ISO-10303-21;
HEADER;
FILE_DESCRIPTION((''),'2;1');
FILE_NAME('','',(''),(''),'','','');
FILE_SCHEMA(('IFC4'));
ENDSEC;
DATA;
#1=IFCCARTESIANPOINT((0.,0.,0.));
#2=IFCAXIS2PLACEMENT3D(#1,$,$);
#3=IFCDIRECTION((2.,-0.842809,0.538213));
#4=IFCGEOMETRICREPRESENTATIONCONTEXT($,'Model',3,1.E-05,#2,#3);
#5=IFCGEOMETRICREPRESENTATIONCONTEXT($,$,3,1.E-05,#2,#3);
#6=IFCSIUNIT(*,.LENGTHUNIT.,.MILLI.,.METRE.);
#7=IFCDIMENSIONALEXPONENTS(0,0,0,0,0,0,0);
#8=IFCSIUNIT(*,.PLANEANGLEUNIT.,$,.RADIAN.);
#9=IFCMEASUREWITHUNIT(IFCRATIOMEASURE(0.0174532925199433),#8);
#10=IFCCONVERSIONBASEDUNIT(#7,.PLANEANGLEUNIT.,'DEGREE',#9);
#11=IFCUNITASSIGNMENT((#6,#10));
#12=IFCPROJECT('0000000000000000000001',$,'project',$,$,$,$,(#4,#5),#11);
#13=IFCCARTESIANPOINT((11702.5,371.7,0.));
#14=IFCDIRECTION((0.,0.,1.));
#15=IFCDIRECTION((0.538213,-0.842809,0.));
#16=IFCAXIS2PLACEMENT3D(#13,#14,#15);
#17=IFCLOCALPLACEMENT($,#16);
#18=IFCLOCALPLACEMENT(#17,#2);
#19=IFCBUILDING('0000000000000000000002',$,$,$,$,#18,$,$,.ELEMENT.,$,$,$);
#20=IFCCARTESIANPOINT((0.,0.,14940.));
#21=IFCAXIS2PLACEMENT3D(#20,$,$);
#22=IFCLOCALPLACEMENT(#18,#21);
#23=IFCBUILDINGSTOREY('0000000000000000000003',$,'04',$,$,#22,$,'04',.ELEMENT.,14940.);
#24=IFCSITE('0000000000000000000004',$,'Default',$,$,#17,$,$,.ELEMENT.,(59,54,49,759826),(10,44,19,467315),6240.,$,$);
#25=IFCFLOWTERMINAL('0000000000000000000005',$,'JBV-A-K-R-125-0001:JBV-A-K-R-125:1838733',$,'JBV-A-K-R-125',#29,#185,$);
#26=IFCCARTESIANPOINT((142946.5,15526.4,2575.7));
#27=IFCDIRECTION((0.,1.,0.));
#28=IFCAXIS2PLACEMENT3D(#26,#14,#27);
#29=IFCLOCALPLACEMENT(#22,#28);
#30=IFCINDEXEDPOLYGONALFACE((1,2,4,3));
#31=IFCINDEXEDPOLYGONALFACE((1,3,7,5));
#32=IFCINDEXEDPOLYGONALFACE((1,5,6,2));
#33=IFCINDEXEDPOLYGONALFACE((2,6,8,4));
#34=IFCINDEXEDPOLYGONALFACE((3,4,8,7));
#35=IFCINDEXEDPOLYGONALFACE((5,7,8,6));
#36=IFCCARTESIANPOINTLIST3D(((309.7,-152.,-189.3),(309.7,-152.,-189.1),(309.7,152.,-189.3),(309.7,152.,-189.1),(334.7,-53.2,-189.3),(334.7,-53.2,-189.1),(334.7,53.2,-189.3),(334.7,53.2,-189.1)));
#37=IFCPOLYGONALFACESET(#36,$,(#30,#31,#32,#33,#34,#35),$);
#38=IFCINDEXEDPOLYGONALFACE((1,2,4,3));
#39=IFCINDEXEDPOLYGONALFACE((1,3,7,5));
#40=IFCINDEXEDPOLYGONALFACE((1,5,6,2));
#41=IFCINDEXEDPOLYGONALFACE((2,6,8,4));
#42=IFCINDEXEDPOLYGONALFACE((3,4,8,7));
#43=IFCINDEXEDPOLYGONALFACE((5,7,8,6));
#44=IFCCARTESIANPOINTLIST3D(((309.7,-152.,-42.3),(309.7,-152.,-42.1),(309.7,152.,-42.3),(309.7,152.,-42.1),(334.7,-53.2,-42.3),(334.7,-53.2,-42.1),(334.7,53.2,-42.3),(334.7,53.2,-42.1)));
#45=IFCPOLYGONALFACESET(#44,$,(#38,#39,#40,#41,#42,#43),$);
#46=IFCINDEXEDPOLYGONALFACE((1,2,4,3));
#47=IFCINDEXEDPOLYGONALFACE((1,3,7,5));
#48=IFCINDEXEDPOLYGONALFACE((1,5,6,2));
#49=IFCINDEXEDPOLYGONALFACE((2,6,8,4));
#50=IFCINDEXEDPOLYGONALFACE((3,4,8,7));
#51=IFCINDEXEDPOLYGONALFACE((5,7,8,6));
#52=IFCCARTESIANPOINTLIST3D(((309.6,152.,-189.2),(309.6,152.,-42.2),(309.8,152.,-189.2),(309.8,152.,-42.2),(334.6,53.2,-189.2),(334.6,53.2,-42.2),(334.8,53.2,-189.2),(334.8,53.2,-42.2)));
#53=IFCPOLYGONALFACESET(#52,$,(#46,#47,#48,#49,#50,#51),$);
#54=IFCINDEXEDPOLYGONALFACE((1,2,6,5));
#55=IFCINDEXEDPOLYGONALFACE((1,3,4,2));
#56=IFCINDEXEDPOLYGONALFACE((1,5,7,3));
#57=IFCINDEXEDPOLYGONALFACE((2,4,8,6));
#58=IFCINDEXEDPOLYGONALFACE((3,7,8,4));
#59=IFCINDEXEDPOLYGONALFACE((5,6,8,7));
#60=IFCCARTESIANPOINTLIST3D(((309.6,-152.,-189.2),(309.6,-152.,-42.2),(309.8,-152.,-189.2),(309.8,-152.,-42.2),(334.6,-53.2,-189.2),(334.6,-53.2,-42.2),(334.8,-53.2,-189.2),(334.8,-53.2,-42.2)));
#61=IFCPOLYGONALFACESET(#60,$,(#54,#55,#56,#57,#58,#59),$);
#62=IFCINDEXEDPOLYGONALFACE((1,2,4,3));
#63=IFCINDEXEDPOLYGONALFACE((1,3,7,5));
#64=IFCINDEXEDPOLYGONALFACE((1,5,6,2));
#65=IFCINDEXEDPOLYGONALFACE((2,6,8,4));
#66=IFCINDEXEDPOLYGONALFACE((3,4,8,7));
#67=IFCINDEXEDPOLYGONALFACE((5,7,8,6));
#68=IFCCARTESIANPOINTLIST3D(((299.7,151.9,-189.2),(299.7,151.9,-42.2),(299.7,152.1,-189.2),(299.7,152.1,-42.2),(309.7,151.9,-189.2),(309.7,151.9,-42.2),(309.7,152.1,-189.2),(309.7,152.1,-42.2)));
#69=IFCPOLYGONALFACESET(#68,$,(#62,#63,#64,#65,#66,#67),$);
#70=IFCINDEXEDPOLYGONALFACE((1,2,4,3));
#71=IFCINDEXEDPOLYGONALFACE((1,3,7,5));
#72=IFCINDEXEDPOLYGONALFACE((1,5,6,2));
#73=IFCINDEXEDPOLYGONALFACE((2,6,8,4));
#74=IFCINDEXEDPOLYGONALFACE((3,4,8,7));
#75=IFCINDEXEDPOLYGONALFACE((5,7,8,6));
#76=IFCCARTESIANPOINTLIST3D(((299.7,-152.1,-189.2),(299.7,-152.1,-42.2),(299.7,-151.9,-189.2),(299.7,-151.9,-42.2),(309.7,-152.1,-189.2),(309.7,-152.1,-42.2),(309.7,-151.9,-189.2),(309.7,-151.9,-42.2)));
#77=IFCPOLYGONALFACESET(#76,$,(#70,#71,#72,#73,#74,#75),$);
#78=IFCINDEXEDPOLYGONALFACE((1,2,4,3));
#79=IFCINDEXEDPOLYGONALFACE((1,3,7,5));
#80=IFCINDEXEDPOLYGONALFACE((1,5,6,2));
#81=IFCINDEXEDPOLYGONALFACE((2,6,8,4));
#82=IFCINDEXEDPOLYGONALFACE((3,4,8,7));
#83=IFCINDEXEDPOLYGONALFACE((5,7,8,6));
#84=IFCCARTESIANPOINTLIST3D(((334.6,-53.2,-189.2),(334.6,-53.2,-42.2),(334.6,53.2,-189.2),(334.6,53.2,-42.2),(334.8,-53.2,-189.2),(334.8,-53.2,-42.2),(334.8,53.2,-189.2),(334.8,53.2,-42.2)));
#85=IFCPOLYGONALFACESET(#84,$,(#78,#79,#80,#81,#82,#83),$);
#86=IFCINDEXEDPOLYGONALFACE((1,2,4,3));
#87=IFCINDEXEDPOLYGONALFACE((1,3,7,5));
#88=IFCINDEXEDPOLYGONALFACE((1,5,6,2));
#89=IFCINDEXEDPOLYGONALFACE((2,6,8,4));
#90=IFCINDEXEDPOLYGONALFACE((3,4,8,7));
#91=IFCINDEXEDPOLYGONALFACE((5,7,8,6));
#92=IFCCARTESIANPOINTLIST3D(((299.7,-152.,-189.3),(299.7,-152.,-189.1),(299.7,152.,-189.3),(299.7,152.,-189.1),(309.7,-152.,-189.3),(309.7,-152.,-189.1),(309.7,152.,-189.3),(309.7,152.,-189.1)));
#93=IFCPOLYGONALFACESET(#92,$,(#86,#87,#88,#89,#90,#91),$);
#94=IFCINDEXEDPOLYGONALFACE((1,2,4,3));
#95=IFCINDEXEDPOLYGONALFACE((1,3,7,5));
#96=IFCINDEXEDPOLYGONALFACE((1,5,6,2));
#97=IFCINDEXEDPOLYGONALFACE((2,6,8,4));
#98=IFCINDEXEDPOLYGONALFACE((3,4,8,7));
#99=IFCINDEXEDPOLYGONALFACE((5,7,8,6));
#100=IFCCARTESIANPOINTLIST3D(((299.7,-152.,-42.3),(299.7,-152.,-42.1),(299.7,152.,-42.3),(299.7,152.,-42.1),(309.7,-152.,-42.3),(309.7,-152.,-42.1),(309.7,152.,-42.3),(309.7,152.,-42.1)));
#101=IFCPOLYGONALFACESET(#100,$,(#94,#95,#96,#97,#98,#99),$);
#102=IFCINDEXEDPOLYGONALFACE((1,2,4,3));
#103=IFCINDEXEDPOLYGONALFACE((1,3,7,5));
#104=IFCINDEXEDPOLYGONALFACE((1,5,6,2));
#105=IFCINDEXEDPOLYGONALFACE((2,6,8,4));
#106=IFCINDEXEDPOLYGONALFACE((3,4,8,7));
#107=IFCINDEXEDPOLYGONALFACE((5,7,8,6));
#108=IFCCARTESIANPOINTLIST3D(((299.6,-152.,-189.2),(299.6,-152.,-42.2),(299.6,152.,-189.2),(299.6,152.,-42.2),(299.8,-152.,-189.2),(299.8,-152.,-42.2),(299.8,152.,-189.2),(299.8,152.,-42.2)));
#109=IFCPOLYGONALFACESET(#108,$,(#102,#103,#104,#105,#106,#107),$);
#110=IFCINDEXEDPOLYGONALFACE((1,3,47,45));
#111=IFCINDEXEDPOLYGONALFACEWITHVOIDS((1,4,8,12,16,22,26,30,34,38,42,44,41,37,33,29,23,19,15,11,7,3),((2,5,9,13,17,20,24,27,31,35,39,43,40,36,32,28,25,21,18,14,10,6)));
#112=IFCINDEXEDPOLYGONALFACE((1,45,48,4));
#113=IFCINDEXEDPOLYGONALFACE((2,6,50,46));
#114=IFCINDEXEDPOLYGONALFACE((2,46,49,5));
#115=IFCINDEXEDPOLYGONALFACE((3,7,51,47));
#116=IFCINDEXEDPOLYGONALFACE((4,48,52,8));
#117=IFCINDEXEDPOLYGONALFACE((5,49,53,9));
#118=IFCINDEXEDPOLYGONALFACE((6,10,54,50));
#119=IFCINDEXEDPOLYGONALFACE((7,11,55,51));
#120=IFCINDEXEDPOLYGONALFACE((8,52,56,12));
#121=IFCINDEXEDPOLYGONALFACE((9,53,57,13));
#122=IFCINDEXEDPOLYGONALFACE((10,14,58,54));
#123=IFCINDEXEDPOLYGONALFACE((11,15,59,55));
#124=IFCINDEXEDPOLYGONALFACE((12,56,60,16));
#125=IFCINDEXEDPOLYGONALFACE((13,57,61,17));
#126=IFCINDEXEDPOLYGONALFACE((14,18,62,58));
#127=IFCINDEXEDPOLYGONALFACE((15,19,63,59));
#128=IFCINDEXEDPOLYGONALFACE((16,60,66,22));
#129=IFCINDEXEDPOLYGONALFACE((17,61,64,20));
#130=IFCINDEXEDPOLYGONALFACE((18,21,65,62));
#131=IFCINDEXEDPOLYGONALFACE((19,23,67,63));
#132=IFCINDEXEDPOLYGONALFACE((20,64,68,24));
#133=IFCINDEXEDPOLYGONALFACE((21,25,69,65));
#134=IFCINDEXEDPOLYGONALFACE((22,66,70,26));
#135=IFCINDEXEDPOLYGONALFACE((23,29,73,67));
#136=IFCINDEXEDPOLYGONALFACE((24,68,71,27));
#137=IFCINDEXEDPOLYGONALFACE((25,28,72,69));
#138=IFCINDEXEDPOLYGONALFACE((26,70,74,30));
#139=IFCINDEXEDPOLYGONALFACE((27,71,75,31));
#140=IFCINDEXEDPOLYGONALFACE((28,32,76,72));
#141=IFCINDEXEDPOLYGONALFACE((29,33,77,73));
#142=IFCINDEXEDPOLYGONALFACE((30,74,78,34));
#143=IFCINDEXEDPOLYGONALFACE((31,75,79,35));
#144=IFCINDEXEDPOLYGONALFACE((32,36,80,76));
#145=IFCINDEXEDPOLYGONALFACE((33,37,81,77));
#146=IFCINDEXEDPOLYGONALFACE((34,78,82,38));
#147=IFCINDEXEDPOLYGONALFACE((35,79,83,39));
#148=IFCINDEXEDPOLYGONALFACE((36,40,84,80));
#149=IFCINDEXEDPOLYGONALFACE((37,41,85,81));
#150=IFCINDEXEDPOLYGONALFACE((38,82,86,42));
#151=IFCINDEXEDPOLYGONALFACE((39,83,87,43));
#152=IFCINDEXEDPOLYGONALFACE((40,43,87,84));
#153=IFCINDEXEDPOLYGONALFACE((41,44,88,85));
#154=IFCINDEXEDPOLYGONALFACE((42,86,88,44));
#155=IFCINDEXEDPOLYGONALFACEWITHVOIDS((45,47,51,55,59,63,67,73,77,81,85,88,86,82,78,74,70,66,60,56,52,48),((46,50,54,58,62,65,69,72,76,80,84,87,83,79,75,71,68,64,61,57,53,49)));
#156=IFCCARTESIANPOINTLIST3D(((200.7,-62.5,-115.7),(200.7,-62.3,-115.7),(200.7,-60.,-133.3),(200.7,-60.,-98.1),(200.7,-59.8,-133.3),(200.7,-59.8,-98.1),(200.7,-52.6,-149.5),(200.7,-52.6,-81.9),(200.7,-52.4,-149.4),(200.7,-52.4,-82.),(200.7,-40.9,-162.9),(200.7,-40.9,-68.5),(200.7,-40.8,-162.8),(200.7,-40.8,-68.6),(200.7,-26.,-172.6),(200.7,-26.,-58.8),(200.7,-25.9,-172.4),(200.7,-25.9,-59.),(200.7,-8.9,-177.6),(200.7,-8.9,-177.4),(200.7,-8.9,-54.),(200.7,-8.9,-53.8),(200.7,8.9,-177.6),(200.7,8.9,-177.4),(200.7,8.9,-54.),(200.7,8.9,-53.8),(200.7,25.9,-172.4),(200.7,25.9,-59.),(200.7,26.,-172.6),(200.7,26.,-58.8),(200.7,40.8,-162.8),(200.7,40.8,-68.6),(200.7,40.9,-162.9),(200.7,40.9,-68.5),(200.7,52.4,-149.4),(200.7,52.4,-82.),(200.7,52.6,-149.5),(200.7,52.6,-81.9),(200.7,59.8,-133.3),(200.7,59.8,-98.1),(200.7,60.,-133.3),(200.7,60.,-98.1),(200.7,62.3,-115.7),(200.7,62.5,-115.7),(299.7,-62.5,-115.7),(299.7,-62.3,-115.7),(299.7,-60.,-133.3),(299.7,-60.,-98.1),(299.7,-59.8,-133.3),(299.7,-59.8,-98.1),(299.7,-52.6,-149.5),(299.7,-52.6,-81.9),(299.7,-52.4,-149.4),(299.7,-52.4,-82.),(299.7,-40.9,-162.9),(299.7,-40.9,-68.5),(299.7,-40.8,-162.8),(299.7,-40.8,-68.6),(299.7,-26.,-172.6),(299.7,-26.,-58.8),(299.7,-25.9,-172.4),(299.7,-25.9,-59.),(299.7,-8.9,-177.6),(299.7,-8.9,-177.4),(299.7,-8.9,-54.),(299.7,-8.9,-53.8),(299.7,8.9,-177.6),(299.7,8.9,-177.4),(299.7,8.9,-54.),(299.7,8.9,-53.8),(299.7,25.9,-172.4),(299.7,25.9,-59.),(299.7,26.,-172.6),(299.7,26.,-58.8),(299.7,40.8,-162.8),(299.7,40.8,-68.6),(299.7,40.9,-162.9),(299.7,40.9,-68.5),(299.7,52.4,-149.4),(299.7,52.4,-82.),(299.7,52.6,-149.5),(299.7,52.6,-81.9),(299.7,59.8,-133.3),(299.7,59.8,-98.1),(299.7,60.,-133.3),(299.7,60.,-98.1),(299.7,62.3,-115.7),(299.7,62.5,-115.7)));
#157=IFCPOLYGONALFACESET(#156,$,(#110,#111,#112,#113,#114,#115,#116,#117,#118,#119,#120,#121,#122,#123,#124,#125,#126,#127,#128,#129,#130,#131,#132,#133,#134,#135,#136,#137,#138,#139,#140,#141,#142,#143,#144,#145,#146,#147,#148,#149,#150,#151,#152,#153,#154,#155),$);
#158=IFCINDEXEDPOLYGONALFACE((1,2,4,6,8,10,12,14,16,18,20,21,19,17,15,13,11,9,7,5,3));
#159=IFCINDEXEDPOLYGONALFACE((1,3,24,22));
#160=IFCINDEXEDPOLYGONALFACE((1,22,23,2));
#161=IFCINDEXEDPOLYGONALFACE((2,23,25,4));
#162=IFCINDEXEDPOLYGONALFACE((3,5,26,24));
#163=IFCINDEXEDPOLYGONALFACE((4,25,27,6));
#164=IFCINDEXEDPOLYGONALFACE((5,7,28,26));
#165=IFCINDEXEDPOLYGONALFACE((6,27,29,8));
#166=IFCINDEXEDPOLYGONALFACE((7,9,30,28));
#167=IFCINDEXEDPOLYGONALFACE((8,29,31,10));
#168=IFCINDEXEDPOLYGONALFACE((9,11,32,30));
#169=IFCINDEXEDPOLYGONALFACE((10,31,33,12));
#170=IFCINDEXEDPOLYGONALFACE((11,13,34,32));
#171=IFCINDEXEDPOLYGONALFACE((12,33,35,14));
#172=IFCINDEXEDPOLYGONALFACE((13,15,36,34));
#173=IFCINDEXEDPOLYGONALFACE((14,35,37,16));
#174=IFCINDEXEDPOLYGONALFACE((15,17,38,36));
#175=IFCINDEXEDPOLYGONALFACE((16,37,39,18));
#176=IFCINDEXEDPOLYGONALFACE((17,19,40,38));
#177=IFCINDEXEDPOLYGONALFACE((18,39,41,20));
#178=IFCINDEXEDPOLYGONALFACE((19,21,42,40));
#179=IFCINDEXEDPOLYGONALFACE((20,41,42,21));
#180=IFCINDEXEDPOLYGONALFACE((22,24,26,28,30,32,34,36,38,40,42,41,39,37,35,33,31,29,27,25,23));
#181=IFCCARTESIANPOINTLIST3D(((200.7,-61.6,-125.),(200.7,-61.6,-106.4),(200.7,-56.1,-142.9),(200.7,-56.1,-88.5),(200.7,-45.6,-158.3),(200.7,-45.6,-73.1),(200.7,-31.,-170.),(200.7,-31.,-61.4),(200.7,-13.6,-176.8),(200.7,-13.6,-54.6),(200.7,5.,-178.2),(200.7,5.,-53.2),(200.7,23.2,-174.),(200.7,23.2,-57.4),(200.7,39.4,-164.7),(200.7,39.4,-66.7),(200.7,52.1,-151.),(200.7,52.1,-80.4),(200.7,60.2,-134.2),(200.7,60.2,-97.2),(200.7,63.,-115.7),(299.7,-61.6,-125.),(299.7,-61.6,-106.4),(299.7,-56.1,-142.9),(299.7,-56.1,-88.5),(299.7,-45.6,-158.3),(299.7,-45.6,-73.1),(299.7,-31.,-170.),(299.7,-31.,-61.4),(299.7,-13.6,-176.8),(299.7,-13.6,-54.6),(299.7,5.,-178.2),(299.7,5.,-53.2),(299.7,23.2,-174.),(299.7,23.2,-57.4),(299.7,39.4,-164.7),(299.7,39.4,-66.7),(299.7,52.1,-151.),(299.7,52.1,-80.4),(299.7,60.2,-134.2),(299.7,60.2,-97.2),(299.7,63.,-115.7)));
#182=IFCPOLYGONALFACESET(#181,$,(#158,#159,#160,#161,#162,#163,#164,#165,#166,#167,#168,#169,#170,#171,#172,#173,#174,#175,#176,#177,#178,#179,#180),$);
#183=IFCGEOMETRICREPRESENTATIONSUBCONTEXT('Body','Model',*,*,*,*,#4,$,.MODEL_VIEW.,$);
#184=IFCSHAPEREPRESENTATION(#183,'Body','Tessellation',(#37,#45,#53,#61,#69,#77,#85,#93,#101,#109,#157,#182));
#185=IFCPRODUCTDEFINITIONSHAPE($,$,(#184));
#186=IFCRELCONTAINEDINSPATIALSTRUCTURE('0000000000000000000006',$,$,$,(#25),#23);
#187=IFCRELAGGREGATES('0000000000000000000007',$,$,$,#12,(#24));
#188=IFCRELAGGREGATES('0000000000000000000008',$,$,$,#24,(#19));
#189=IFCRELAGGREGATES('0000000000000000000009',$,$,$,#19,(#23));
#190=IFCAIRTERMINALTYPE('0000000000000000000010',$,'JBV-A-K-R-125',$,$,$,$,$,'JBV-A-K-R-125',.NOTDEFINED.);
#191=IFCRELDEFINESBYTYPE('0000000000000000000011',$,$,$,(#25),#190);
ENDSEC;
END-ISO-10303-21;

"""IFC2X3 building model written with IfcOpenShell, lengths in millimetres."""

from ifc_helpers import new_model, entity, si_unit, converted_unit, direction, frame, frame_2d, origin, origin_2d_with_axis, place, context, subcontext, project, spatial, polyline, circle_curve, parameter, trimmed, segment, composite_curve, rectangle, circle, outline, extrude, source, transform, mapped, type_object, type_shapes, element, save


model = new_model("IFC2X3")

# Units and contexts
model_context = context("Model", 3, precision=1e-05, world=origin(), true_north=direction((2.0, -0.842809, 0.538213)))
context_of_model = context(None, 3, precision=1e-05, world=origin(), true_north=direction((2.0, -0.842809, 0.538213)))
body_context = subcontext(model_context, "Body", "Model", "MODEL_VIEW")
ifc_project = project(units=[si_unit("LENGTHUNIT", "METRE", prefix="MILLI"), converted_unit("PLANEANGLEUNIT", "DEGREE", entity("IfcRatioMeasure", 0.0174532925199433), si_unit("PLANEANGLEUNIT", "RADIAN"), dimensions=[0, 0, 0, 0, 0, 0, 0])], contexts=[model_context, context_of_model])

# Site, building, storey
site_placement = place(None, frame((11702.5, 371.7, 0.0), z_axis=(0.0, 0.0, 1.0), x_axis=(0.538213, -0.842809, 0.0)))
site = spatial("IfcSite", under=ifc_project, at=site_placement, Name="Default", CompositionType="ELEMENT", RefLatitude=(59, 54, 49, 759826), RefLongitude=(10, 44, 19, 467315), RefElevation=6240.0)
building_placement = place(site_placement, origin())
building = spatial("IfcBuilding", under=site, at=building_placement, CompositionType="ELEMENT")
storey_placement = place(building_placement, frame((0.0, 0.0, 14940.0)))
storey = spatial("IfcBuildingStorey", under=building, at=storey_placement, Name="04", LongName="04", CompositionType="ELEMENT", Elevation=14940.0)

# Flow terminal
air_terminal_type_1 = type_object("IfcAirTerminalType", Name="JBV-A-K-R-125", ElementType="JBV-A-K-R-125", PredefinedType="NOTDEFINED")
shared_shape_1 = source(origin(), body_context, "Body", "SweptSolid", [
    extrude(outline(polyline([(-152.0, -12.5), (152.0, -12.5), (53.2, 12.5), (-53.2, 12.5), (-152.0, -12.5)])), frame((322.2, 0.0, -189.3), z_axis=(0.0, 0.0, 1.0), x_axis=(0.0, -1.0, 0.0)), (0.0, 0.0, 1.0), 0.2),
    extrude(outline(polyline([(-152.0, -12.5), (152.0, -12.5), (53.2, 12.5), (-53.2, 12.5), (-152.0, -12.5)])), frame((322.2, 0.0, -42.3), z_axis=(0.0, 0.0, 1.0), x_axis=(0.0, -1.0, 0.0)), (0.0, 0.0, 1.0), 0.2),
    extrude(rectangle(XDim=0.2, YDim=101.9, at=frame_2d((0.0, 0.0), x_axis=(1.0, 0.0))), frame((322.2, 102.6, -189.2), z_axis=(0.0, 0.0, 1.0), x_axis=(0.969446, 0.245305, 0.0)), (0.0, 0.0, 1.0), 147.0),
    extrude(rectangle(XDim=0.2, YDim=101.9, at=frame_2d((0.0, 0.0), x_axis=(1.0, 0.0))), frame((322.2, -102.6, -189.2), z_axis=(0.0, 0.0, 1.0), x_axis=(-0.969446, 0.245305, 0.0)), (0.0, 0.0, 1.0), 147.0),
    extrude(rectangle(XDim=0.2, YDim=10.0, at=frame_2d((0.0, 0.0), x_axis=(1.0, 0.0))), frame((304.7, 152.0, -189.2), z_axis=(0.0, 0.0, 1.0), x_axis=(0.0, 1.0, 0.0)), (0.0, 0.0, 1.0), 147.0),
    extrude(rectangle(XDim=0.2, YDim=10.0, at=frame_2d((0.0, 0.0), x_axis=(1.0, 0.0))), frame((304.7, -152.0, -189.2), z_axis=(0.0, 0.0, 1.0), x_axis=(0.0, 1.0, 0.0)), (0.0, 0.0, 1.0), 147.0),
    extrude(rectangle(XDim=0.2, YDim=106.4, at=frame_2d((0.0, 0.0), x_axis=(1.0, 0.0))), frame((334.7, 0.0, -189.2)), (0.0, 0.0, 1.0), 147.0),
    extrude(rectangle(XDim=304.0, YDim=10.0, at=frame_2d((0.0, 0.0), x_axis=(1.0, 0.0))), frame((304.7, 0.0, -189.3), z_axis=(0.0, 0.0, 1.0), x_axis=(0.0, -1.0, 0.0)), (0.0, 0.0, 1.0), 0.2),
    extrude(rectangle(XDim=304.0, YDim=10.0, at=frame_2d((0.0, 0.0), x_axis=(1.0, 0.0))), frame((304.7, 0.0, -42.3), z_axis=(0.0, 0.0, 1.0), x_axis=(0.0, -1.0, 0.0)), (0.0, 0.0, 1.0), 0.2),
    extrude(rectangle(XDim=0.2, YDim=304.0, at=frame_2d((0.0, 0.0), x_axis=(1.0, 0.0))), frame((299.7, 0.0, -189.2)), (0.0, 0.0, 1.0), 147.0),
    extrude(outline(composite_curve([segment(trimmed(circle_curve(origin_2d_with_axis(), 62.5), [parameter(0.0)], [parameter(180.0)], True, "PARAMETER"), True, "CONTINUOUS"), segment(trimmed(circle_curve(origin_2d_with_axis(), 62.5), [parameter(180.0)], [parameter(360.0)], True, "PARAMETER"), True, "CONTINUOUS")], self_intersect=False), holes=[composite_curve([segment(trimmed(circle_curve(origin_2d_with_axis(), 62.3), [parameter(180.0)], [parameter(360.0)], True, "PARAMETER"), False, "CONTINUOUS"), segment(trimmed(circle_curve(origin_2d_with_axis(), 62.3), [parameter(0.0)], [parameter(180.0)], True, "PARAMETER"), False, "CONTINUOUS")], self_intersect=False)]), frame((200.7, 0.0, -115.7), z_axis=(1.0, 0.0, 0.0), x_axis=(0.0, 1.0, 0.0)), (0.0, 0.0, 1.0), 99.0),
    extrude(circle(Radius=62.6, at=frame_2d((0.0, 0.0), x_axis=(1.0, 0.0))), frame((200.7, 0.3, -115.7), z_axis=(1.0, 0.0, 0.0), x_axis=(0.0, 1.0, 0.0)), (0.0, 0.0, 1.0), 99.0),
])
type_shapes(air_terminal_type_1, [shared_shape_1])
for number, where, z_axis, x_axis, name in (
    (1, (142946.5, 15526.4, 2575.7), (0.0, 0.0, 1.0), (0.0, 1.0, 0.0), "JBV-A-K-R-125-0001:JBV-A-K-R-125:1838733"),
):
    element("IfcFlowTerminal", number, at=place(storey_placement, frame(where, z_axis=z_axis, x_axis=x_axis)), inside=storey, type_object=air_terminal_type_1, Name=name, ObjectType="JBV-A-K-R-125", context=body_context, shape_type="MappedRepresentation", body=[
        mapped(shared_shape_1, transform((0.0, 0.0, 0.0), scale=1.0)),
    ])

save(model, "model.ifc")
